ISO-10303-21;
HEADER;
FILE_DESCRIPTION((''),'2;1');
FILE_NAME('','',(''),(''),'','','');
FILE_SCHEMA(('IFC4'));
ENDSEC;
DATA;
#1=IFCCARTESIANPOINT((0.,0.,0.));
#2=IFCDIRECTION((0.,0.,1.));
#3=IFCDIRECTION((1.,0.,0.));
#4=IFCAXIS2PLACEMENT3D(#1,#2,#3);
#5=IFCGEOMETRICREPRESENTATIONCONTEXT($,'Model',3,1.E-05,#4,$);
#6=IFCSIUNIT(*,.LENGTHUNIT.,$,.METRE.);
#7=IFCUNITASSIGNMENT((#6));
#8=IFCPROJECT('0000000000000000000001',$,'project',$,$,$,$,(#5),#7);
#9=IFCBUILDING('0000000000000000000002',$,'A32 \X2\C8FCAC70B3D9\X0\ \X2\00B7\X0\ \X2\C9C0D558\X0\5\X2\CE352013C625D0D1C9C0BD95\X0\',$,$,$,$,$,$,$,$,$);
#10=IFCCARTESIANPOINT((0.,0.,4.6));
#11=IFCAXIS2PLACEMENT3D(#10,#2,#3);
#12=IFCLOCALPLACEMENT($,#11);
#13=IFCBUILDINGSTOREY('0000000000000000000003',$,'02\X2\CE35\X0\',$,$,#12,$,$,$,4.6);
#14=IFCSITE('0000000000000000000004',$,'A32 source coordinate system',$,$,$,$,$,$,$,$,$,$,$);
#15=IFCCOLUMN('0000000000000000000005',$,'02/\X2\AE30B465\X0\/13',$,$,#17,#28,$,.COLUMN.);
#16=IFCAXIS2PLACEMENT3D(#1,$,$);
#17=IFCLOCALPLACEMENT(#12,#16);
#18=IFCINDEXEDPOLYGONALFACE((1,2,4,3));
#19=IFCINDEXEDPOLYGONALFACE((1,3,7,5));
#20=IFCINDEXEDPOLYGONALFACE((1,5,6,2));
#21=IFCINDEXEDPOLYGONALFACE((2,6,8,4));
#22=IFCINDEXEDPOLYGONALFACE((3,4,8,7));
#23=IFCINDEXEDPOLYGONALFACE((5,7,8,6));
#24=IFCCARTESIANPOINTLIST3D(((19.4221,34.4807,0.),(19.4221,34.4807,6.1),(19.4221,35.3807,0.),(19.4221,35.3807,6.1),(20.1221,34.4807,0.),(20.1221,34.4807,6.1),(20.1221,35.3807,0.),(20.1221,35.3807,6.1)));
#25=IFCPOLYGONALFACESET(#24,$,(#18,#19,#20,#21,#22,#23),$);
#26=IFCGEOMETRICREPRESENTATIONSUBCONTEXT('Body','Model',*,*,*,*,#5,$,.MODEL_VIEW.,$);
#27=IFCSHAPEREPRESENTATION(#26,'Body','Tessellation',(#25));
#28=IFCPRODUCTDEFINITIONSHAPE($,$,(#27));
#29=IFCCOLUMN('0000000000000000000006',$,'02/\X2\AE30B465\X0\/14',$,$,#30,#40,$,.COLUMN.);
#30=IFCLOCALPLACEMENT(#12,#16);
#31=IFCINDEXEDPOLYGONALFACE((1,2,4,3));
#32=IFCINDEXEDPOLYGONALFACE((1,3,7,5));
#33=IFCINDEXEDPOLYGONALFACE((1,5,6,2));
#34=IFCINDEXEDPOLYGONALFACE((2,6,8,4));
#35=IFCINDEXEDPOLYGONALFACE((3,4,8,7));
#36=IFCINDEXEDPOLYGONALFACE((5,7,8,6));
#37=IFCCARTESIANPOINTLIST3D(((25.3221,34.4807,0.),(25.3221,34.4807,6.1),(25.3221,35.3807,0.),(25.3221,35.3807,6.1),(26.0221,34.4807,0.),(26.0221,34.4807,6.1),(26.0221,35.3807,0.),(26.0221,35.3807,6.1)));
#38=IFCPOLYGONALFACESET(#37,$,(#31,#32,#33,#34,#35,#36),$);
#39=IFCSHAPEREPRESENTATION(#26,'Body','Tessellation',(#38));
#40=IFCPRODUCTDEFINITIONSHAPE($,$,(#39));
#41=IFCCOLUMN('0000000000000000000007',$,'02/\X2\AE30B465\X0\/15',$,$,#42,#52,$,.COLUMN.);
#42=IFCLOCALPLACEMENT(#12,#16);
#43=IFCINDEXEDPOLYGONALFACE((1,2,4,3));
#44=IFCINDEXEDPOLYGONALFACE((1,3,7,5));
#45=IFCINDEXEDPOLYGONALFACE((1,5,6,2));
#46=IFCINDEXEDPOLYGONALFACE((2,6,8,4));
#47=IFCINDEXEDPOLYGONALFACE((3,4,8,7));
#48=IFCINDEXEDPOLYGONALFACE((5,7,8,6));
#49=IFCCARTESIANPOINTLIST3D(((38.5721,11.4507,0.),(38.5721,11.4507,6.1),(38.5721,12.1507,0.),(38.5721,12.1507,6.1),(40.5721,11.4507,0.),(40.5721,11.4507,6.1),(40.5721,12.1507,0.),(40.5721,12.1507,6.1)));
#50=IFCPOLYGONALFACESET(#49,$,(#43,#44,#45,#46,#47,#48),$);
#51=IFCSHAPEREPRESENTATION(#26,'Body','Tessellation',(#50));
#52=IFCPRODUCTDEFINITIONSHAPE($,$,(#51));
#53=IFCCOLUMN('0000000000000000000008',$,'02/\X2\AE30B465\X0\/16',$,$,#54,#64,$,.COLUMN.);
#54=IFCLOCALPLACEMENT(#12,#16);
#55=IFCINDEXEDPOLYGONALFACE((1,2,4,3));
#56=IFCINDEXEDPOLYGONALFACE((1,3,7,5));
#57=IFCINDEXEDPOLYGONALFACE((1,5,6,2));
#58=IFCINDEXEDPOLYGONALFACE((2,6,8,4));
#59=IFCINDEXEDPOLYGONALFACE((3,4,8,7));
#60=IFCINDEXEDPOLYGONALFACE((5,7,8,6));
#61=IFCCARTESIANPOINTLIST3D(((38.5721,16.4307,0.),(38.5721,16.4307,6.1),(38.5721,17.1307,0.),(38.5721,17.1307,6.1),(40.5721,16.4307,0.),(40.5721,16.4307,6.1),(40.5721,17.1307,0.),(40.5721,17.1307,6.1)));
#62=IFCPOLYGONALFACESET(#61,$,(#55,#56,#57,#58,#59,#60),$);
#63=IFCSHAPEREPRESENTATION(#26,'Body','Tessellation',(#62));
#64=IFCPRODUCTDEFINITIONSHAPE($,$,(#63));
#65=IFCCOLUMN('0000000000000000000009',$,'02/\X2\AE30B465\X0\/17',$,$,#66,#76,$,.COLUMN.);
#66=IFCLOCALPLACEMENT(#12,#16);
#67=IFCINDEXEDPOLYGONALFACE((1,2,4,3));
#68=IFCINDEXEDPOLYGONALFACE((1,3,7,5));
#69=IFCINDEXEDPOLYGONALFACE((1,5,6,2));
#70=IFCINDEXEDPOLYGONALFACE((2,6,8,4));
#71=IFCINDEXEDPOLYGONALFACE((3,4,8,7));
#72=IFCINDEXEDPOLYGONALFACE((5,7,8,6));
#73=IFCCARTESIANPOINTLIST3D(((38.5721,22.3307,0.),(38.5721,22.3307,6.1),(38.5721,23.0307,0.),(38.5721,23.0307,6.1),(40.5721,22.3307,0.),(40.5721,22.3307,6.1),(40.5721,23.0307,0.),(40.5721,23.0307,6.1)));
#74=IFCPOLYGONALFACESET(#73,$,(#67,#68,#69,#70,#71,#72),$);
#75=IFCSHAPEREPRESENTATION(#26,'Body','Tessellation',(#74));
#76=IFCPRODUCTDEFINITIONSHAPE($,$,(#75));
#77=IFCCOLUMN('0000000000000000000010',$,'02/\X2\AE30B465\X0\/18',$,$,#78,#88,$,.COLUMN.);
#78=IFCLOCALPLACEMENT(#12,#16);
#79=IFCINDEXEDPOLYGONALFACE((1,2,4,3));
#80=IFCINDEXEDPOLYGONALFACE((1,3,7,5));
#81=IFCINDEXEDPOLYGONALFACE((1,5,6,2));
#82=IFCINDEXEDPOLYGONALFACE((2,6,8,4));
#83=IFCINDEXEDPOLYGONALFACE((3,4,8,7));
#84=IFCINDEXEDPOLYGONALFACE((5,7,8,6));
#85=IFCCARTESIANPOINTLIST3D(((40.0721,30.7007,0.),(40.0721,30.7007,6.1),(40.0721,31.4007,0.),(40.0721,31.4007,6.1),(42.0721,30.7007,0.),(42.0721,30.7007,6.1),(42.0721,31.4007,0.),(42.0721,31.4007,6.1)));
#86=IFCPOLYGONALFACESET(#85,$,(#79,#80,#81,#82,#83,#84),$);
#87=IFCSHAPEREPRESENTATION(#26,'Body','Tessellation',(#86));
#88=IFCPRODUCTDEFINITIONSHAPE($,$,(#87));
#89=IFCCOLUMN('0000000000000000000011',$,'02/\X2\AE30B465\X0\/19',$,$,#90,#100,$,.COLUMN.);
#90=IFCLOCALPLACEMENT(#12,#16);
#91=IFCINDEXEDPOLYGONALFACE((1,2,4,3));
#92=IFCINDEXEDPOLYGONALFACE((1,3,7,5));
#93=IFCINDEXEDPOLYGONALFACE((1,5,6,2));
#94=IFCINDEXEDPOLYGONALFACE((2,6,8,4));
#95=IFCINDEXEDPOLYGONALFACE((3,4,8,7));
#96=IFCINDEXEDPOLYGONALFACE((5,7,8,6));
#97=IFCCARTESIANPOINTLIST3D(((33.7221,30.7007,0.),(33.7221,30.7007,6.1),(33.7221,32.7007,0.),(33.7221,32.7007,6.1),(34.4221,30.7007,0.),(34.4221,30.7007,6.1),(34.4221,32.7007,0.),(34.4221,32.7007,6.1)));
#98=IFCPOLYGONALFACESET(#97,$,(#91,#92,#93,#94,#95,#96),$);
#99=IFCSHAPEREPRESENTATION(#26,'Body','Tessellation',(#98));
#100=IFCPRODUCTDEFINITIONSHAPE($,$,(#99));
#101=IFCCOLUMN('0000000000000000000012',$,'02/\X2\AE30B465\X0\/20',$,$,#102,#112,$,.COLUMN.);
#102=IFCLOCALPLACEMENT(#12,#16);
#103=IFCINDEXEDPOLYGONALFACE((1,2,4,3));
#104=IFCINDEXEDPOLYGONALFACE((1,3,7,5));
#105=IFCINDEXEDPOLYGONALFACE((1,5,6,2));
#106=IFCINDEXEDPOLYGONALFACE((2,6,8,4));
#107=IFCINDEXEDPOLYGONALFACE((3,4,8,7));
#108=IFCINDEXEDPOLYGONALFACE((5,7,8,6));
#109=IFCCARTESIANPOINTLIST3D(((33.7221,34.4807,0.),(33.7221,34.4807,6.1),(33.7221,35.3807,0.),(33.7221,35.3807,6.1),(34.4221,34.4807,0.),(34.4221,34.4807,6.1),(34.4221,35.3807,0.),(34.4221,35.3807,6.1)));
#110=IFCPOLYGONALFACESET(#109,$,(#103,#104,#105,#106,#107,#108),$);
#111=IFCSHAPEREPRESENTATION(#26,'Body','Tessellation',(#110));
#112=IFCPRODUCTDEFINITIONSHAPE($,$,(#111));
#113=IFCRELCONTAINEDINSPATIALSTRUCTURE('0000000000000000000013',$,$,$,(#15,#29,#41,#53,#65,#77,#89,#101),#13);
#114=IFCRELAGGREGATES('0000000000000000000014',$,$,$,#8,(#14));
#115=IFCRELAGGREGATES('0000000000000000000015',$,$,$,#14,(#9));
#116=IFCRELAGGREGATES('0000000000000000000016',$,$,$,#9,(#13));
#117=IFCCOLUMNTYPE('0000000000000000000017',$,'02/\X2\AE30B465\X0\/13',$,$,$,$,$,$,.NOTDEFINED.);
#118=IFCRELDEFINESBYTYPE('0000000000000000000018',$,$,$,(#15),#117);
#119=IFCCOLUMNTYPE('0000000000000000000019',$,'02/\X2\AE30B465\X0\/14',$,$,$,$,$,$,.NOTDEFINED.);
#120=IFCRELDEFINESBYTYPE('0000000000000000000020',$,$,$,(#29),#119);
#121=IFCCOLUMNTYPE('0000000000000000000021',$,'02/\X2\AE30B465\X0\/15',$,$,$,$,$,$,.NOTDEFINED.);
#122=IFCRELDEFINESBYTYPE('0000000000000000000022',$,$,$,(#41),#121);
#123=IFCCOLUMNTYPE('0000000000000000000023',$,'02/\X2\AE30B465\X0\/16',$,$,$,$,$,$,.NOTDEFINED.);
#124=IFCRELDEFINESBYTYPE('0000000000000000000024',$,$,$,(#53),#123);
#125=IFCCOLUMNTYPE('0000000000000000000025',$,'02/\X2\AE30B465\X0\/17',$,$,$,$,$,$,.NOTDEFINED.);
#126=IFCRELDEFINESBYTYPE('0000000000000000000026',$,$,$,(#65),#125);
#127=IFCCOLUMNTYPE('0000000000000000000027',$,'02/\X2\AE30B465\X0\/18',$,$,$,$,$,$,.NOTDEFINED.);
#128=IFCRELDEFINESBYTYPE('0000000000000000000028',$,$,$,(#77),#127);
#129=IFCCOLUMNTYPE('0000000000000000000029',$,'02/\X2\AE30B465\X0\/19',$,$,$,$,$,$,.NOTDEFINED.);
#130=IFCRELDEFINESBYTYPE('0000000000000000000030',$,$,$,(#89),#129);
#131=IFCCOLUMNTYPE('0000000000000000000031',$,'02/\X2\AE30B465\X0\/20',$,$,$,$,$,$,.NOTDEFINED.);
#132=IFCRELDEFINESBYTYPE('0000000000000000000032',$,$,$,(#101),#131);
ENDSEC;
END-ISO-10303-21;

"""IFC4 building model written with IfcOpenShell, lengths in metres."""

from ifc_helpers import new_model, si_unit, frame, origin, origin_with_axes, place, context, subcontext, project, spatial, polyline, outline, extrude, source, transform, mapped, type_object, type_shapes, element, save


model = new_model("IFC4")

# Units and contexts
model_context = context("Model", 3, precision=1e-05, world=origin_with_axes())
body_context = subcontext(model_context, "Body", "Model", "MODEL_VIEW")
ifc_project = project(units=[si_unit("LENGTHUNIT", "METRE")], contexts=[model_context])

# Site, building, storey
site = spatial("IfcSite", under=ifc_project, Name="A32 source coordinate system")
building = spatial("IfcBuilding", under=site, Name="A32 주거동 · 지하5층–옥탑지붕")
storey_placement = place(None, frame((0.0, 0.0, 4.6), z_axis=(0.0, 0.0, 1.0), x_axis=(1.0, 0.0, 0.0)))
storey = spatial("IfcBuildingStorey", under=building, at=storey_placement, Name="02층", Elevation=4.6)

# Columns
column_type_1 = type_object("IfcColumnType", Name="02/기둥/13", PredefinedType="NOTDEFINED")
shared_shape_1 = source(origin(), body_context, "Body", "SweptSolid", [
    extrude(outline(polyline([(19.4221, 35.3807), (20.1221, 35.3807), (20.1221, 34.4807), (19.4221, 34.4807), (19.4221, 35.3807)])), origin(), (0.0, 0.0, 1.0), 6.1),
])
type_shapes(column_type_1, [shared_shape_1])
column_1_placement = place(storey_placement, origin_with_axes())
element("IfcColumn", 1, at=column_1_placement, inside=storey, type_object=column_type_1, Name="02/기둥/13", PredefinedType="COLUMN", context=body_context, shape_type="MappedRepresentation", body=[
    mapped(shared_shape_1, transform((0.0, 0.0, 0.0), scale=1.0)),
])
column_type_2 = type_object("IfcColumnType", Name="02/기둥/14", PredefinedType="NOTDEFINED")
shared_shape_2 = source(origin(), body_context, "Body", "SweptSolid", [
    extrude(outline(polyline([(25.3221, 35.3807), (26.0221, 35.3807), (26.0221, 34.4807), (25.3221, 34.4807), (25.3221, 35.3807)])), origin(), (0.0, 0.0, 1.0), 6.1),
])
type_shapes(column_type_2, [shared_shape_2])
column_2_placement = place(storey_placement, origin_with_axes())
element("IfcColumn", 2, at=column_2_placement, inside=storey, type_object=column_type_2, Name="02/기둥/14", PredefinedType="COLUMN", context=body_context, shape_type="MappedRepresentation", body=[
    mapped(shared_shape_2, transform((0.0, 0.0, 0.0), scale=1.0)),
])
column_type_3 = type_object("IfcColumnType", Name="02/기둥/15", PredefinedType="NOTDEFINED")
shared_shape_3 = source(origin(), body_context, "Body", "SweptSolid", [
    extrude(outline(polyline([(38.5721, 12.1507), (40.5721, 12.1507), (40.5721, 11.4507), (38.5721, 11.4507), (38.5721, 12.1507)])), origin(), (0.0, 0.0, 1.0), 6.1),
])
type_shapes(column_type_3, [shared_shape_3])
column_3_placement = place(storey_placement, origin_with_axes())
element("IfcColumn", 3, at=column_3_placement, inside=storey, type_object=column_type_3, Name="02/기둥/15", PredefinedType="COLUMN", context=body_context, shape_type="MappedRepresentation", body=[
    mapped(shared_shape_3, transform((0.0, 0.0, 0.0), scale=1.0)),
])
column_type_4 = type_object("IfcColumnType", Name="02/기둥/16", PredefinedType="NOTDEFINED")
shared_shape_4 = source(origin(), body_context, "Body", "SweptSolid", [
    extrude(outline(polyline([(40.5721, 17.1307), (40.5721, 16.4307), (38.5721, 16.4307), (38.5721, 17.1307), (40.5721, 17.1307)])), origin(), (0.0, 0.0, 1.0), 6.1),
])
type_shapes(column_type_4, [shared_shape_4])
column_4_placement = place(storey_placement, origin_with_axes())
element("IfcColumn", 4, at=column_4_placement, inside=storey, type_object=column_type_4, Name="02/기둥/16", PredefinedType="COLUMN", context=body_context, shape_type="MappedRepresentation", body=[
    mapped(shared_shape_4, transform((0.0, 0.0, 0.0), scale=1.0)),
])
column_type_5 = type_object("IfcColumnType", Name="02/기둥/17", PredefinedType="NOTDEFINED")
shared_shape_5 = source(origin(), body_context, "Body", "SweptSolid", [
    extrude(outline(polyline([(38.5721, 23.0307), (40.5721, 23.0307), (40.5721, 22.3307), (38.5721, 22.3307), (38.5721, 23.0307)])), origin(), (0.0, 0.0, 1.0), 6.1),
])
type_shapes(column_type_5, [shared_shape_5])
column_5_placement = place(storey_placement, origin_with_axes())
element("IfcColumn", 5, at=column_5_placement, inside=storey, type_object=column_type_5, Name="02/기둥/17", PredefinedType="COLUMN", context=body_context, shape_type="MappedRepresentation", body=[
    mapped(shared_shape_5, transform((0.0, 0.0, 0.0), scale=1.0)),
])
column_type_6 = type_object("IfcColumnType", Name="02/기둥/18", PredefinedType="NOTDEFINED")
shared_shape_6 = source(origin(), body_context, "Body", "SweptSolid", [
    extrude(outline(polyline([(42.0721, 31.4007), (42.0721, 30.7007), (40.0721, 30.7007), (40.0721, 31.4007), (42.0721, 31.4007)])), origin(), (0.0, 0.0, 1.0), 6.1),
])
type_shapes(column_type_6, [shared_shape_6])
column_6_placement = place(storey_placement, origin_with_axes())
element("IfcColumn", 6, at=column_6_placement, inside=storey, type_object=column_type_6, Name="02/기둥/18", PredefinedType="COLUMN", context=body_context, shape_type="MappedRepresentation", body=[
    mapped(shared_shape_6, transform((0.0, 0.0, 0.0), scale=1.0)),
])
column_type_7 = type_object("IfcColumnType", Name="02/기둥/19", PredefinedType="NOTDEFINED")
shared_shape_7 = source(origin(), body_context, "Body", "SweptSolid", [
    extrude(outline(polyline([(33.7221, 30.7007), (33.7221, 32.7007), (34.4221, 32.7007), (34.4221, 30.7007), (33.7221, 30.7007)])), origin(), (0.0, 0.0, 1.0), 6.1),
])
type_shapes(column_type_7, [shared_shape_7])
column_7_placement = place(storey_placement, origin_with_axes())
element("IfcColumn", 7, at=column_7_placement, inside=storey, type_object=column_type_7, Name="02/기둥/19", PredefinedType="COLUMN", context=body_context, shape_type="MappedRepresentation", body=[
    mapped(shared_shape_7, transform((0.0, 0.0, 0.0), scale=1.0)),
])
column_type_8 = type_object("IfcColumnType", Name="02/기둥/20", PredefinedType="NOTDEFINED")
shared_shape_8 = source(origin(), body_context, "Body", "SweptSolid", [
    extrude(outline(polyline([(33.7221, 35.3807), (34.4221, 35.3807), (34.4221, 34.4807), (33.7221, 34.4807), (33.7221, 35.3807)])), origin(), (0.0, 0.0, 1.0), 6.1),
])
type_shapes(column_type_8, [shared_shape_8])
column_8_placement = place(storey_placement, origin_with_axes())
element("IfcColumn", 8, at=column_8_placement, inside=storey, type_object=column_type_8, Name="02/기둥/20", PredefinedType="COLUMN", context=body_context, shape_type="MappedRepresentation", body=[
    mapped(shared_shape_8, transform((0.0, 0.0, 0.0), scale=1.0)),
])

save(model, "model.ifc")
